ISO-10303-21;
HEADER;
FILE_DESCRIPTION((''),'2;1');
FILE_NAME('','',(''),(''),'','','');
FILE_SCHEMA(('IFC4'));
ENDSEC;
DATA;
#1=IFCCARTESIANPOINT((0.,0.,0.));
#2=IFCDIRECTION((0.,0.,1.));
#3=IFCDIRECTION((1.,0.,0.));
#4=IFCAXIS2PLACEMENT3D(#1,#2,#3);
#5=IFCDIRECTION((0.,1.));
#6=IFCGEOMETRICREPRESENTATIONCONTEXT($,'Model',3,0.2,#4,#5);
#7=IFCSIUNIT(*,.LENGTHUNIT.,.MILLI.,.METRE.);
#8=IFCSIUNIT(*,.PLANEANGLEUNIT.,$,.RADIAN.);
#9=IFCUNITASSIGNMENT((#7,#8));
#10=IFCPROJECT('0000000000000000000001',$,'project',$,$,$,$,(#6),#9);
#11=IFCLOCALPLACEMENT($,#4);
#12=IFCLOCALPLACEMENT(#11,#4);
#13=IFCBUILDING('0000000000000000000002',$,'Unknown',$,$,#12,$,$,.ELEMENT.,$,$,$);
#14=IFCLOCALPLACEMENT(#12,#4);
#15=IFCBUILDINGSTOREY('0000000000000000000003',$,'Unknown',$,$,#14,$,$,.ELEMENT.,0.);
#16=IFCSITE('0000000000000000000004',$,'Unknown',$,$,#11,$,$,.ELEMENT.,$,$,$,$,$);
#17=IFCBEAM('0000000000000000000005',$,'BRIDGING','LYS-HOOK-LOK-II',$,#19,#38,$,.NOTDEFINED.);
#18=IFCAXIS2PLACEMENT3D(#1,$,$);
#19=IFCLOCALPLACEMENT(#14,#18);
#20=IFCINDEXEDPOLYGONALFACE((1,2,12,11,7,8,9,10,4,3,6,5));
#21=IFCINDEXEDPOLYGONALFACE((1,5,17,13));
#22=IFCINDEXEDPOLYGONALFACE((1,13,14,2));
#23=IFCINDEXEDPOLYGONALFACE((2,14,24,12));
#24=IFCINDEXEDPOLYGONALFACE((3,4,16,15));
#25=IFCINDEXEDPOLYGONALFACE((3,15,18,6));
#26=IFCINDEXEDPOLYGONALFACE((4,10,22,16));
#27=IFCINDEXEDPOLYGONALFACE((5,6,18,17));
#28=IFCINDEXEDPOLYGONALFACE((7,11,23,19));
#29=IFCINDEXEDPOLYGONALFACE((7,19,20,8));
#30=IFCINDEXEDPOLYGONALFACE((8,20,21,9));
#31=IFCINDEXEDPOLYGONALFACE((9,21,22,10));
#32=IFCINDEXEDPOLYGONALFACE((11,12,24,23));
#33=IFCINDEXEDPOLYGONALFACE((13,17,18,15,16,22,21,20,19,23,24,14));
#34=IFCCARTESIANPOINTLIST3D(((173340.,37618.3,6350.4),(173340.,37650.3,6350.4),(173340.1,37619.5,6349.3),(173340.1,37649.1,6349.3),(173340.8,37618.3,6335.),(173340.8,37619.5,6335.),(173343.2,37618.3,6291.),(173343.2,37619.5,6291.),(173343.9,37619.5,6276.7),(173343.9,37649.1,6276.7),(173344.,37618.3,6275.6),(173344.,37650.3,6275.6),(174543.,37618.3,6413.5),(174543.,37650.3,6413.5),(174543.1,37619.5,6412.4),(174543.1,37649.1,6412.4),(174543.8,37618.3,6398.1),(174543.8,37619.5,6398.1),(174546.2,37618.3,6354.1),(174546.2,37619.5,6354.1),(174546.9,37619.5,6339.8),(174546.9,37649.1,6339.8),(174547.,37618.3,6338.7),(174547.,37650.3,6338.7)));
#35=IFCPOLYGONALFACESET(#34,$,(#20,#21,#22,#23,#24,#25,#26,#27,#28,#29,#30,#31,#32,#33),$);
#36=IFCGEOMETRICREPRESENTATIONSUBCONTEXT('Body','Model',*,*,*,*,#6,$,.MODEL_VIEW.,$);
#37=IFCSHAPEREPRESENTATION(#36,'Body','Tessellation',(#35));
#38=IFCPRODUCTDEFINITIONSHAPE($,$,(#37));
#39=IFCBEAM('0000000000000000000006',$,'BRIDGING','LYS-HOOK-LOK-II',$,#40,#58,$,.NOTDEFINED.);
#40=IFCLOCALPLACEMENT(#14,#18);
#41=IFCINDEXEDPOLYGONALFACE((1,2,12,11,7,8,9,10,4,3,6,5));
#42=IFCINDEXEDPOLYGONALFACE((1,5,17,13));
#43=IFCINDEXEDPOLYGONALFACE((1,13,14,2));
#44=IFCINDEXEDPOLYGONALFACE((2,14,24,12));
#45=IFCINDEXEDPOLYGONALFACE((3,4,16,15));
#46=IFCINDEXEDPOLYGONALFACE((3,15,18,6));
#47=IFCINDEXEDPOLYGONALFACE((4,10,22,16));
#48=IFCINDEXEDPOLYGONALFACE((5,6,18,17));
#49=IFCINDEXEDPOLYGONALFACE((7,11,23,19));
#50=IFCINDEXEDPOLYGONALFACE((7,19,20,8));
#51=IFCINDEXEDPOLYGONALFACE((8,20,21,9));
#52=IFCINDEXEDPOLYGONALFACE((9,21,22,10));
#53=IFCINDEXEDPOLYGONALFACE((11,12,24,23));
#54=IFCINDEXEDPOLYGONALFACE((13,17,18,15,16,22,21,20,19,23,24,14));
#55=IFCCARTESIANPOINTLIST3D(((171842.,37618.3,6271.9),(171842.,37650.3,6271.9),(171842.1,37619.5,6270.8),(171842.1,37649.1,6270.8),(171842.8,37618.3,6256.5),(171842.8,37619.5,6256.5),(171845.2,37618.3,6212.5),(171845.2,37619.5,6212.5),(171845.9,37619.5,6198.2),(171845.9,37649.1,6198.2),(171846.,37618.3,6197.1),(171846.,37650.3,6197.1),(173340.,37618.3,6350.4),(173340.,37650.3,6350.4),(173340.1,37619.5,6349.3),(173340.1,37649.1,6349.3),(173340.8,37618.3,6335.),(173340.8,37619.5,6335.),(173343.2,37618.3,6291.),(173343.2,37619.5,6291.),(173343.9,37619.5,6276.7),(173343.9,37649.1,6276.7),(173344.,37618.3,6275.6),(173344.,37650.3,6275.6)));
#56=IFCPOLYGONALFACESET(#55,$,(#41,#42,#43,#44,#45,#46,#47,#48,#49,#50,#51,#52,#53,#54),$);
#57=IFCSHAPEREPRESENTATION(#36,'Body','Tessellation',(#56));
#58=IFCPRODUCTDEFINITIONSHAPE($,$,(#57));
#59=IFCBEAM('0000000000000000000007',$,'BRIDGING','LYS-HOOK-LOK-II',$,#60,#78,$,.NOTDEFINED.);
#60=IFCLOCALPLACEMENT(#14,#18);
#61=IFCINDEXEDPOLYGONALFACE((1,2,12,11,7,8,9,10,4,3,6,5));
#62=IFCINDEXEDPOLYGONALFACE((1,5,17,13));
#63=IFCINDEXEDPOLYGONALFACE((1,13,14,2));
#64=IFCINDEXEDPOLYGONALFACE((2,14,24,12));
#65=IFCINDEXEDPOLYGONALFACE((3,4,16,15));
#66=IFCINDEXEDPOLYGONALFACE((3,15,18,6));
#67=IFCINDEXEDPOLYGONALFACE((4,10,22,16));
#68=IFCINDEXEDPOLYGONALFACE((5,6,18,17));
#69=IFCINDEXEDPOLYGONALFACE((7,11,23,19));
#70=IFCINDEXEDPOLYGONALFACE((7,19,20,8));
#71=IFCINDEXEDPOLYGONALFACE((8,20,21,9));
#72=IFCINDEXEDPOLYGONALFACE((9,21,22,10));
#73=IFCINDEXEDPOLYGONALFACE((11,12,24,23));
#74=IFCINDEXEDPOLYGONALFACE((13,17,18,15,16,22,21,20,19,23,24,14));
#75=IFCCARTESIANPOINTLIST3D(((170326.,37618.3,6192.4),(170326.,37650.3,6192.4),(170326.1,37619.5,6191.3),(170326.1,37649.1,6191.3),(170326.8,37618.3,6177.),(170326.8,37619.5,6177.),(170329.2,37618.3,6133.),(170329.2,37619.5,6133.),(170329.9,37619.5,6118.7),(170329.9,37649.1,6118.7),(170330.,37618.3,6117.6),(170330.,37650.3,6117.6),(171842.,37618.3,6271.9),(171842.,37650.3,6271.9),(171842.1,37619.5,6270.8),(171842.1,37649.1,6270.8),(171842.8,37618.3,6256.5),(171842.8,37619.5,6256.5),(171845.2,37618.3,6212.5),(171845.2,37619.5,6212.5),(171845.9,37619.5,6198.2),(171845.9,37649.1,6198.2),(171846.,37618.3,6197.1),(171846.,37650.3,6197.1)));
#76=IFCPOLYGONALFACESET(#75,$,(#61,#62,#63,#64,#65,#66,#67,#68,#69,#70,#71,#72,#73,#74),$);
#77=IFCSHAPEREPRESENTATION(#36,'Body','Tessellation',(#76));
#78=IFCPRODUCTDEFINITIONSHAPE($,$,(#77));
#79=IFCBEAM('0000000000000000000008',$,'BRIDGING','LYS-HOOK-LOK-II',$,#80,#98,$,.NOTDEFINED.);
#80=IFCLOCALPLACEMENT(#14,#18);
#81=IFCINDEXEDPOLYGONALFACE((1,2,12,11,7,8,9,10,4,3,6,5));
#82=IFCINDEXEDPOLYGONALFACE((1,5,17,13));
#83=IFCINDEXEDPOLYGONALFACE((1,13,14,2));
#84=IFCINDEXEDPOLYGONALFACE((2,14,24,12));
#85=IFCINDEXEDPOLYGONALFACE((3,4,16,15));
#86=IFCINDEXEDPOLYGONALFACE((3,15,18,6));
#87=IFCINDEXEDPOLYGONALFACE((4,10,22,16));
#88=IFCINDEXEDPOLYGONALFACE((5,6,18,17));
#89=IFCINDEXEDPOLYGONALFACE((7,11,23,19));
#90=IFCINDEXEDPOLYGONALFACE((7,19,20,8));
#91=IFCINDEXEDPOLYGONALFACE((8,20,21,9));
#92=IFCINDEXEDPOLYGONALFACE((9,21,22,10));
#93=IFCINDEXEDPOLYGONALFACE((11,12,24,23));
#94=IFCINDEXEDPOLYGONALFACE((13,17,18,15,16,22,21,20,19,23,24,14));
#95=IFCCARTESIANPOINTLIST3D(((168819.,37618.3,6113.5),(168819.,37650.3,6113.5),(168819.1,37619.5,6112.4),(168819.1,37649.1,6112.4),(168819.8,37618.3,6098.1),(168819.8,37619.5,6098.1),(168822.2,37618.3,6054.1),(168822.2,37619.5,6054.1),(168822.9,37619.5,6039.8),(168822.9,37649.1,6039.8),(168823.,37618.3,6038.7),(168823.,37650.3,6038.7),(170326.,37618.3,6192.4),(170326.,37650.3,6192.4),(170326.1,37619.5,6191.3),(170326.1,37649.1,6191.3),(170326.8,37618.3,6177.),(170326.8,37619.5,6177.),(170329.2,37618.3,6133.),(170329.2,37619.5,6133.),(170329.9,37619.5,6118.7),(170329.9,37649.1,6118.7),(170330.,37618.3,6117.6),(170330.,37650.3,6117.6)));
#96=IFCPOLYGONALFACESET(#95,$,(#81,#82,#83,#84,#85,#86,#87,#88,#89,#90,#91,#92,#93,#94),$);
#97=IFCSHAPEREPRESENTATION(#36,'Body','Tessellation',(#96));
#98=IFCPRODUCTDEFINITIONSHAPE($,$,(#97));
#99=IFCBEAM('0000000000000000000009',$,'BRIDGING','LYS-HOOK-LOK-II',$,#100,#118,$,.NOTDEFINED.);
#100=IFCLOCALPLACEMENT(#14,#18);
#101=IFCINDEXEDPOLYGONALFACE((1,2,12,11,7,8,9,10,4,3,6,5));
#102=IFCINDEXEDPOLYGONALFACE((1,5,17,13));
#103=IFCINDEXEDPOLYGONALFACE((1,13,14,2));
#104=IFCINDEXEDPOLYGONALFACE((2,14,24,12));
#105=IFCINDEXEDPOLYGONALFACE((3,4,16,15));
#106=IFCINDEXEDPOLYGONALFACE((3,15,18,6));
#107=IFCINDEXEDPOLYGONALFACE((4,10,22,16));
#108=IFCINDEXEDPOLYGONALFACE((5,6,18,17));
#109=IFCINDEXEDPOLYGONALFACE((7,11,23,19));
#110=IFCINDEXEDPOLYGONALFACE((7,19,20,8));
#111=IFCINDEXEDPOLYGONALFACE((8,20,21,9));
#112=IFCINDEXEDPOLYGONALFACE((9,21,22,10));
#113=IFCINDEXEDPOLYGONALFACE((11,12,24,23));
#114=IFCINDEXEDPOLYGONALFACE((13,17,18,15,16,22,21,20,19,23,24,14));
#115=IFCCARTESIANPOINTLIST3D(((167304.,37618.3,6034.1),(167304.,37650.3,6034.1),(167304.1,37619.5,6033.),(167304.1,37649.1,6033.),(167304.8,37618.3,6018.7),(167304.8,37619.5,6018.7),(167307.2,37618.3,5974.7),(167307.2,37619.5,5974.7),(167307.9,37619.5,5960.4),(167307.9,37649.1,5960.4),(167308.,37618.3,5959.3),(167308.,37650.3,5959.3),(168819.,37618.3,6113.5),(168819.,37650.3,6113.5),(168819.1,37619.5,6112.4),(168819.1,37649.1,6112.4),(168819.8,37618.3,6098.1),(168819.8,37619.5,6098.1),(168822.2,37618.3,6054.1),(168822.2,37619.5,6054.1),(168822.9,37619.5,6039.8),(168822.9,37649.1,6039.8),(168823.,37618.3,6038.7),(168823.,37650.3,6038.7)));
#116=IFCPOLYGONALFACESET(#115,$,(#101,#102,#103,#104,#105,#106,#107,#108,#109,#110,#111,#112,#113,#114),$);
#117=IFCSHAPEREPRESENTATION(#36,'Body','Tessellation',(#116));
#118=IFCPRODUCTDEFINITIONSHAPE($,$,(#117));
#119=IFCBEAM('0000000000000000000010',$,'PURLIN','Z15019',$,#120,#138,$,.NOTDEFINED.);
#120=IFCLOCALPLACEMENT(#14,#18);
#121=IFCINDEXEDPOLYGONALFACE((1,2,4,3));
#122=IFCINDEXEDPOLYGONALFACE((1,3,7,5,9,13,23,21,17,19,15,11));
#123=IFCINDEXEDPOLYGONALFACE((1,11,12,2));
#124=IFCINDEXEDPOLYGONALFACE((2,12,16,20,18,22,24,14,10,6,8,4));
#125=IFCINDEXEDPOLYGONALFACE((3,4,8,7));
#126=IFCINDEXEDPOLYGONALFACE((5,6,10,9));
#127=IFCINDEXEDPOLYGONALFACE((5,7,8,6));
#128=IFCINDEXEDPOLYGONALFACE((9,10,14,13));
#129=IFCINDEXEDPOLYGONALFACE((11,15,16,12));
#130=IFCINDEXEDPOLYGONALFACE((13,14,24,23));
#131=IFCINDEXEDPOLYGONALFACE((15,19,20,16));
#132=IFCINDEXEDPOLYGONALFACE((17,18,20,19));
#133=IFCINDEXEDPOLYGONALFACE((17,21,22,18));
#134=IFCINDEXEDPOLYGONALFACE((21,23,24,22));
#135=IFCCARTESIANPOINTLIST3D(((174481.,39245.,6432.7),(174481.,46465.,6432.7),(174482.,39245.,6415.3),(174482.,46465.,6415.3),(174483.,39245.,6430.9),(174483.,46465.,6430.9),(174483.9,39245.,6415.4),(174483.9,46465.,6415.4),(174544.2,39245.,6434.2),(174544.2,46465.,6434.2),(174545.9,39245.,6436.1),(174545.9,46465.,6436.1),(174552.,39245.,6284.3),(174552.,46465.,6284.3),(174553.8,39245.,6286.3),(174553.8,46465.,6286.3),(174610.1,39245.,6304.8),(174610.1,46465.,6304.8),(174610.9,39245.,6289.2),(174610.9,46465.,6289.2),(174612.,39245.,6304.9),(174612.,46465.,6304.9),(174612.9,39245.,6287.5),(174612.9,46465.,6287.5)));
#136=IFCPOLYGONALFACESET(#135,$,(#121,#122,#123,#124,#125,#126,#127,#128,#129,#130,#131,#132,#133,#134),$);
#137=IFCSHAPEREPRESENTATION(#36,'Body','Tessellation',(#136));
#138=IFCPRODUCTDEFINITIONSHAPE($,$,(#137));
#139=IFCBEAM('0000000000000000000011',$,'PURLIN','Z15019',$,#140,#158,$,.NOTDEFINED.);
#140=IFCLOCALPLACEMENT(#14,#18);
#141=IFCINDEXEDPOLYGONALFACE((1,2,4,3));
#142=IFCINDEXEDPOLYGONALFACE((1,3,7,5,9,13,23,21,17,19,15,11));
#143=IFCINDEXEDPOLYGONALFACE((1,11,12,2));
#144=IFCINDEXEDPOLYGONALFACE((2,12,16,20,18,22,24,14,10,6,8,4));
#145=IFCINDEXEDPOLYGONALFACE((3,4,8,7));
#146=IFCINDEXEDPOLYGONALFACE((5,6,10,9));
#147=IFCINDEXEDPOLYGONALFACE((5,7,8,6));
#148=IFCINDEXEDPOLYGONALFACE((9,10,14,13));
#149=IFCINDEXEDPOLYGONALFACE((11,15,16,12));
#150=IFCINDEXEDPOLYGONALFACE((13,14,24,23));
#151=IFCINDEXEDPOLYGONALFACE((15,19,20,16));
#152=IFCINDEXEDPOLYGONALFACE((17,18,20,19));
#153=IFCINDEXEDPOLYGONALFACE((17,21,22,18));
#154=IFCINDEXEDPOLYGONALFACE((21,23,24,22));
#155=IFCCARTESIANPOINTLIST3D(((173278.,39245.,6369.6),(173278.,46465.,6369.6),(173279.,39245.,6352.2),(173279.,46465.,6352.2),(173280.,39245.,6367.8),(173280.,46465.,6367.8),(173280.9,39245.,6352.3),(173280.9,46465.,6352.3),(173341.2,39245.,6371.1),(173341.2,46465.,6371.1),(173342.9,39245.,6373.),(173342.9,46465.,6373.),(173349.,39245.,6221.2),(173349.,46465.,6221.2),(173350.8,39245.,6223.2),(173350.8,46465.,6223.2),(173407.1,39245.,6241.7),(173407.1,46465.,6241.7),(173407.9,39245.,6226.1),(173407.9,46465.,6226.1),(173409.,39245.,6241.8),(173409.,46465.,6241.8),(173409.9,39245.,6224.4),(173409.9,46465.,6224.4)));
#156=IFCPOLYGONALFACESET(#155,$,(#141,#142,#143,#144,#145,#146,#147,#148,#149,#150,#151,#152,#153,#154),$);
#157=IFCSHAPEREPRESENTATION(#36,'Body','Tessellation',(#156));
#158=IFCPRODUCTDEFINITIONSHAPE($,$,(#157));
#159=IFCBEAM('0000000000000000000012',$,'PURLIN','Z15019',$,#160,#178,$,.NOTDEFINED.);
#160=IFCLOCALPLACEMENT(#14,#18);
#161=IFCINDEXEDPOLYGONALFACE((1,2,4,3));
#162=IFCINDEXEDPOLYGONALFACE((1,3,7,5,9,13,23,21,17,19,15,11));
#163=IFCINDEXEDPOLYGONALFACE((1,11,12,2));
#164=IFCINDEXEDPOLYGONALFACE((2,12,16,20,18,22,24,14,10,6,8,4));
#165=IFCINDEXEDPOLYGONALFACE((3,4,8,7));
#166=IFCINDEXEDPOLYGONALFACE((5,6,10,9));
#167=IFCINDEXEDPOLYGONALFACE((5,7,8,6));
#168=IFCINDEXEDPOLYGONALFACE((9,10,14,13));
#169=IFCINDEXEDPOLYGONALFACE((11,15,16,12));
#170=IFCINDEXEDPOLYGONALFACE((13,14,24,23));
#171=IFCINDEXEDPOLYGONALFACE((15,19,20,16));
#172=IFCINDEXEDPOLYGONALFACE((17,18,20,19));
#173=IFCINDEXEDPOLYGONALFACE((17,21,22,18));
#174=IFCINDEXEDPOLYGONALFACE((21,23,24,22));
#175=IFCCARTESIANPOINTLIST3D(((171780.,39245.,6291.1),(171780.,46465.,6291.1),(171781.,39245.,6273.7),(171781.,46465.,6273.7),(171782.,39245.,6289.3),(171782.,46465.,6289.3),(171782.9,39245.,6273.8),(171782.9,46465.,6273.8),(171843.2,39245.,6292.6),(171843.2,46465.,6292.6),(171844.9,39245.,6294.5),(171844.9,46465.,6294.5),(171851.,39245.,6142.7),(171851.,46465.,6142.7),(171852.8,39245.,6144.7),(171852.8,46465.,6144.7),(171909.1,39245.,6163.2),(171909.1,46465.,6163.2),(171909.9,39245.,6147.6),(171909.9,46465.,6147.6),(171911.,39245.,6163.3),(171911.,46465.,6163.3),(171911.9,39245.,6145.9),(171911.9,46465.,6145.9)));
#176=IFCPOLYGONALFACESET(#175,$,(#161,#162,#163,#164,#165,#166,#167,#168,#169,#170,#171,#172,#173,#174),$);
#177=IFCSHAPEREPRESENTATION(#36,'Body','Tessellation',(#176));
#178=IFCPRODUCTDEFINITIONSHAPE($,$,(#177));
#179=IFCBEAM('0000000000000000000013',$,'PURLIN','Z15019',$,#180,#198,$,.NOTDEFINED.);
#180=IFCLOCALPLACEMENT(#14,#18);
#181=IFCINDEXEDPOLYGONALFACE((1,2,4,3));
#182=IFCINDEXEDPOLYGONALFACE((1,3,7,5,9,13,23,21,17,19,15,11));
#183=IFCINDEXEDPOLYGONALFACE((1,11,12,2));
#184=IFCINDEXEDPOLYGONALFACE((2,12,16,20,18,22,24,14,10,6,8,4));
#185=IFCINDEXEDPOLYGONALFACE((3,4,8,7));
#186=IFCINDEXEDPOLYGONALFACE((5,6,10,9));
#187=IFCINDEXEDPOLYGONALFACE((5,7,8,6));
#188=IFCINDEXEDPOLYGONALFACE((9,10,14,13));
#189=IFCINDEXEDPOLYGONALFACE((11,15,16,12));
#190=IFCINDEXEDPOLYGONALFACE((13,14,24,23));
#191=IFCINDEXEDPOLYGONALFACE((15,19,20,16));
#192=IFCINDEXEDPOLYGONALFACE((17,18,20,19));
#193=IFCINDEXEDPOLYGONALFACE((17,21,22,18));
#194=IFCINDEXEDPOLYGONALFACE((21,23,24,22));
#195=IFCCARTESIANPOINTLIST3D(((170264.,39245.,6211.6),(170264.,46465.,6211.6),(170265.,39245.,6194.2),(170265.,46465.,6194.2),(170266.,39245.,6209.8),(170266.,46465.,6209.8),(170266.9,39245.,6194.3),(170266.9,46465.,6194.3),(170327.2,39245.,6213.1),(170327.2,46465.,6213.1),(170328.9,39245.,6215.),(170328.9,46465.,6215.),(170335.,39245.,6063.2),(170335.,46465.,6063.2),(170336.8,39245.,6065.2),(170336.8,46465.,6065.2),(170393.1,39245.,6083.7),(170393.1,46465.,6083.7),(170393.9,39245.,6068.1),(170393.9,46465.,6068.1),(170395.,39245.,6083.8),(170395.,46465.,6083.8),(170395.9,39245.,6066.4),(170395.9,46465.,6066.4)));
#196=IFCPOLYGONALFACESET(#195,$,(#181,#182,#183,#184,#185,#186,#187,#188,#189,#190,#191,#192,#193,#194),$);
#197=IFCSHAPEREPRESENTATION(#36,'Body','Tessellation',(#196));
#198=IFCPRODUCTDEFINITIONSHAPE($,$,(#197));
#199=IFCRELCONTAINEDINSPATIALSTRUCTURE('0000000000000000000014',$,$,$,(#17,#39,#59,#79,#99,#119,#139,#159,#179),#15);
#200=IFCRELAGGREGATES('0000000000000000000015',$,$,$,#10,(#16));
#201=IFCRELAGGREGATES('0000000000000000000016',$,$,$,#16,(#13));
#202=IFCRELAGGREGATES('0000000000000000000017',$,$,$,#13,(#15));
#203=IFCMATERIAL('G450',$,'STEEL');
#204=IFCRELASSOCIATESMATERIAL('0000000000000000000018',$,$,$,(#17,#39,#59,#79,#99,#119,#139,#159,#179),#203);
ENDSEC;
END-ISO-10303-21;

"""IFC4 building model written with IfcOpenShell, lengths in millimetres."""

from ifc_helpers import new_model, si_unit, direction, frame, origin_with_axes, place, context, subcontext, project, spatial, line, indexed_curve, outline, extrude, material, element, save


model = new_model("IFC4")

# Units and contexts
model_context = context("Model", 3, precision=0.2, world=origin_with_axes(), true_north=direction((0.0, 1.0)))
body_context = subcontext(model_context, "Body", "Model", "MODEL_VIEW")
ifc_project = project(units=[si_unit("LENGTHUNIT", "METRE", prefix="MILLI"), si_unit("PLANEANGLEUNIT", "RADIAN")], contexts=[model_context])

# Site, building, storey
site_placement = place(None, origin_with_axes())
site = spatial("IfcSite", under=ifc_project, at=site_placement, Name="Unknown", CompositionType="ELEMENT")
building_placement = place(site_placement, origin_with_axes())
building = spatial("IfcBuilding", under=site, at=building_placement, Name="Unknown", CompositionType="ELEMENT")
storey_placement = place(building_placement, origin_with_axes())
storey = spatial("IfcBuildingStorey", under=building, at=storey_placement, Name="Unknown", CompositionType="ELEMENT", Elevation=0.0)

# Beams
ifc_material_1 = material(Name="G450", Category="STEEL")
beam_1_placement = place(storey_placement, frame((173342.0, 37634.3, 6313.0), z_axis=(0.0, -1.0, 0.0), x_axis=(0.998627, 0.0, 0.05238)))
element("IfcBeam", 1, at=beam_1_placement, inside=storey, material=ifc_material_1, Name="BRIDGING", Description="LYS-HOOK-LOK-II", PredefinedType="NOTDEFINED", context=body_context, shape_type="SolidModel", body=[
    extrude(outline(indexed_curve([(16.0, -37.5), (16.0, -22.0), (14.8, -22.0), (14.8, -36.3), (-14.8, -36.3), (-14.8, 36.3), (14.8, 36.3), (14.8, 22.0), (16.0, 22.0), (16.0, 37.5), (-16.0, 37.5), (-16.0, -37.5)], segments=[line(1, 2, 3, 4, 5, 6, 7, 8, 9, 10, 11, 12, 1)])), frame((0.0, 0.0, 0.0), z_axis=(-1.0, 0.0, 0.0), x_axis=(0.0, 0.0, 1.0)), (0.0, 0.0, -1.0), 1204.7),
])
beam_2_placement = place(storey_placement, frame((171844.0, 37634.3, 6234.5), z_axis=(0.0, -1.0, 0.0), x_axis=(0.99863, 0.0, 0.052331)))
element("IfcBeam", 2, at=beam_2_placement, inside=storey, material=ifc_material_1, Name="BRIDGING", Description="LYS-HOOK-LOK-II", PredefinedType="NOTDEFINED", context=body_context, shape_type="SolidModel", body=[
    extrude(outline(indexed_curve([(16.0, -37.5), (16.0, -22.0), (14.8, -22.0), (14.8, -36.3), (-14.8, -36.3), (-14.8, 36.3), (14.8, 36.3), (14.8, 22.0), (16.0, 22.0), (16.0, 37.5), (-16.0, 37.5), (-16.0, -37.5)], segments=[line(1, 2, 3, 4, 5, 6, 7, 8, 9, 10, 11, 12, 1)])), frame((0.0, 0.0, 0.0), z_axis=(-1.0, 0.0, 0.0), x_axis=(0.0, 0.0, 1.0)), (0.0, 0.0, -1.0), 1500.1),
])
beam_3_placement = place(storey_placement, frame((170328.0, 37634.3, 6155.0), z_axis=(0.0, -1.0, 0.0), x_axis=(0.998628, 0.0, 0.052369)))
element("IfcBeam", 3, at=beam_3_placement, inside=storey, material=ifc_material_1, Name="BRIDGING", Description="LYS-HOOK-LOK-II", PredefinedType="NOTDEFINED", context=body_context, shape_type="SolidModel", body=[
    extrude(outline(indexed_curve([(16.0, -37.5), (16.0, -22.0), (14.8, -22.0), (14.8, -36.3), (-14.8, -36.3), (-14.8, 36.3), (14.8, 36.3), (14.8, 22.0), (16.0, 22.0), (16.0, 37.5), (-16.0, 37.5), (-16.0, -37.5)], segments=[line(1, 2, 3, 4, 5, 6, 7, 8, 9, 10, 11, 12, 1)])), frame((0.0, 0.0, 0.0), z_axis=(-1.0, 0.0, 0.0), x_axis=(0.0, 0.0, 1.0)), (0.0, 0.0, -1.0), 1518.1),
])
beam_4_placement = place(storey_placement, frame((168821.0, 37634.3, 6076.1), z_axis=(0.0, -1.0, 0.0), x_axis=(0.998632, 0.0, 0.052284)))
element("IfcBeam", 4, at=beam_4_placement, inside=storey, material=ifc_material_1, Name="BRIDGING", Description="LYS-HOOK-LOK-II", PredefinedType="NOTDEFINED", context=body_context, shape_type="SolidModel", body=[
    extrude(outline(indexed_curve([(16.0, -37.5), (16.0, -22.0), (14.8, -22.0), (14.8, -36.3), (-14.8, -36.3), (-14.8, 36.3), (14.8, 36.3), (14.8, 22.0), (16.0, 22.0), (16.0, 37.5), (-16.0, 37.5), (-16.0, -37.5)], segments=[line(1, 2, 3, 4, 5, 6, 7, 8, 9, 10, 11, 12, 1)])), frame((0.0, 0.0, 0.0), z_axis=(-1.0, 0.0, 0.0), x_axis=(0.0, 0.0, 1.0)), (0.0, 0.0, -1.0), 1509.1),
])
beam_5_placement = place(storey_placement, frame((167306.0, 37634.3, 5996.7), z_axis=(0.0, -1.0, 0.0), x_axis=(0.998629, 0.0, 0.052337)))
element("IfcBeam", 5, at=beam_5_placement, inside=storey, material=ifc_material_1, Name="BRIDGING", Description="LYS-HOOK-LOK-II", PredefinedType="NOTDEFINED", context=body_context, shape_type="SolidModel", body=[
    extrude(outline(indexed_curve([(16.0, -37.5), (16.0, -22.0), (14.8, -22.0), (14.8, -36.3), (-14.8, -36.3), (-14.8, 36.3), (14.8, 36.3), (14.8, 22.0), (16.0, 22.0), (16.0, 37.5), (-16.0, 37.5), (-16.0, -37.5)], segments=[line(1, 2, 3, 4, 5, 6, 7, 8, 9, 10, 11, 12, 1)])), frame((0.0, 0.0, 0.0), z_axis=(-1.0, 0.0, 0.0), x_axis=(0.0, 0.0, 1.0)), (0.0, 0.0, -1.0), 1517.1),
])
for number, where, z_axis, x_axis, name in (
    (6, (174549.0, 39245.0, 6360.2), (0.99863, 0.0, 0.052336), (0.0, 1.0, 0.0), "PURLIN"),
    (7, (173346.0, 39245.0, 6297.1), (0.99863, 0.0, 0.052336), (0.0, 1.0, 0.0), "PURLIN"),
    (8, (171848.0, 39245.0, 6218.6), (0.99863, 0.0, 0.052336), (0.0, 1.0, 0.0), "PURLIN"),
    (9, (170332.0, 39245.0, 6139.1), (0.99863, 0.0, 0.052336), (0.0, 1.0, 0.0), "PURLIN"),
):
    element("IfcBeam", number, at=place(storey_placement, frame(where, z_axis=z_axis, x_axis=x_axis)), inside=storey, material=ifc_material_1, Name=name, Description="Z15019", PredefinedType="NOTDEFINED", context=body_context, shape_type="SolidModel", body=[
        extrude(outline(indexed_curve([(60.0, -76.0), (60.0, -58.5), (58.1, -58.5), (58.1, -74.1), (0.9, -74.1), (0.9, 76.0), (-64.0, 76.0), (-64.0, 58.5), (-62.1, 58.5), (-62.1, 74.1), (-0.9, 74.1), (-0.9, -76.0)], segments=[line(1, 2, 3, 4, 5, 6, 7, 8, 9, 10, 11, 12, 1)])), frame((0.0, 0.0, 0.0), z_axis=(-1.0, 0.0, 0.0), x_axis=(0.0, 0.0, 1.0)), (0.0, 0.0, -1.0), 7220.0),
    ])

save(model, "model.ifc")
